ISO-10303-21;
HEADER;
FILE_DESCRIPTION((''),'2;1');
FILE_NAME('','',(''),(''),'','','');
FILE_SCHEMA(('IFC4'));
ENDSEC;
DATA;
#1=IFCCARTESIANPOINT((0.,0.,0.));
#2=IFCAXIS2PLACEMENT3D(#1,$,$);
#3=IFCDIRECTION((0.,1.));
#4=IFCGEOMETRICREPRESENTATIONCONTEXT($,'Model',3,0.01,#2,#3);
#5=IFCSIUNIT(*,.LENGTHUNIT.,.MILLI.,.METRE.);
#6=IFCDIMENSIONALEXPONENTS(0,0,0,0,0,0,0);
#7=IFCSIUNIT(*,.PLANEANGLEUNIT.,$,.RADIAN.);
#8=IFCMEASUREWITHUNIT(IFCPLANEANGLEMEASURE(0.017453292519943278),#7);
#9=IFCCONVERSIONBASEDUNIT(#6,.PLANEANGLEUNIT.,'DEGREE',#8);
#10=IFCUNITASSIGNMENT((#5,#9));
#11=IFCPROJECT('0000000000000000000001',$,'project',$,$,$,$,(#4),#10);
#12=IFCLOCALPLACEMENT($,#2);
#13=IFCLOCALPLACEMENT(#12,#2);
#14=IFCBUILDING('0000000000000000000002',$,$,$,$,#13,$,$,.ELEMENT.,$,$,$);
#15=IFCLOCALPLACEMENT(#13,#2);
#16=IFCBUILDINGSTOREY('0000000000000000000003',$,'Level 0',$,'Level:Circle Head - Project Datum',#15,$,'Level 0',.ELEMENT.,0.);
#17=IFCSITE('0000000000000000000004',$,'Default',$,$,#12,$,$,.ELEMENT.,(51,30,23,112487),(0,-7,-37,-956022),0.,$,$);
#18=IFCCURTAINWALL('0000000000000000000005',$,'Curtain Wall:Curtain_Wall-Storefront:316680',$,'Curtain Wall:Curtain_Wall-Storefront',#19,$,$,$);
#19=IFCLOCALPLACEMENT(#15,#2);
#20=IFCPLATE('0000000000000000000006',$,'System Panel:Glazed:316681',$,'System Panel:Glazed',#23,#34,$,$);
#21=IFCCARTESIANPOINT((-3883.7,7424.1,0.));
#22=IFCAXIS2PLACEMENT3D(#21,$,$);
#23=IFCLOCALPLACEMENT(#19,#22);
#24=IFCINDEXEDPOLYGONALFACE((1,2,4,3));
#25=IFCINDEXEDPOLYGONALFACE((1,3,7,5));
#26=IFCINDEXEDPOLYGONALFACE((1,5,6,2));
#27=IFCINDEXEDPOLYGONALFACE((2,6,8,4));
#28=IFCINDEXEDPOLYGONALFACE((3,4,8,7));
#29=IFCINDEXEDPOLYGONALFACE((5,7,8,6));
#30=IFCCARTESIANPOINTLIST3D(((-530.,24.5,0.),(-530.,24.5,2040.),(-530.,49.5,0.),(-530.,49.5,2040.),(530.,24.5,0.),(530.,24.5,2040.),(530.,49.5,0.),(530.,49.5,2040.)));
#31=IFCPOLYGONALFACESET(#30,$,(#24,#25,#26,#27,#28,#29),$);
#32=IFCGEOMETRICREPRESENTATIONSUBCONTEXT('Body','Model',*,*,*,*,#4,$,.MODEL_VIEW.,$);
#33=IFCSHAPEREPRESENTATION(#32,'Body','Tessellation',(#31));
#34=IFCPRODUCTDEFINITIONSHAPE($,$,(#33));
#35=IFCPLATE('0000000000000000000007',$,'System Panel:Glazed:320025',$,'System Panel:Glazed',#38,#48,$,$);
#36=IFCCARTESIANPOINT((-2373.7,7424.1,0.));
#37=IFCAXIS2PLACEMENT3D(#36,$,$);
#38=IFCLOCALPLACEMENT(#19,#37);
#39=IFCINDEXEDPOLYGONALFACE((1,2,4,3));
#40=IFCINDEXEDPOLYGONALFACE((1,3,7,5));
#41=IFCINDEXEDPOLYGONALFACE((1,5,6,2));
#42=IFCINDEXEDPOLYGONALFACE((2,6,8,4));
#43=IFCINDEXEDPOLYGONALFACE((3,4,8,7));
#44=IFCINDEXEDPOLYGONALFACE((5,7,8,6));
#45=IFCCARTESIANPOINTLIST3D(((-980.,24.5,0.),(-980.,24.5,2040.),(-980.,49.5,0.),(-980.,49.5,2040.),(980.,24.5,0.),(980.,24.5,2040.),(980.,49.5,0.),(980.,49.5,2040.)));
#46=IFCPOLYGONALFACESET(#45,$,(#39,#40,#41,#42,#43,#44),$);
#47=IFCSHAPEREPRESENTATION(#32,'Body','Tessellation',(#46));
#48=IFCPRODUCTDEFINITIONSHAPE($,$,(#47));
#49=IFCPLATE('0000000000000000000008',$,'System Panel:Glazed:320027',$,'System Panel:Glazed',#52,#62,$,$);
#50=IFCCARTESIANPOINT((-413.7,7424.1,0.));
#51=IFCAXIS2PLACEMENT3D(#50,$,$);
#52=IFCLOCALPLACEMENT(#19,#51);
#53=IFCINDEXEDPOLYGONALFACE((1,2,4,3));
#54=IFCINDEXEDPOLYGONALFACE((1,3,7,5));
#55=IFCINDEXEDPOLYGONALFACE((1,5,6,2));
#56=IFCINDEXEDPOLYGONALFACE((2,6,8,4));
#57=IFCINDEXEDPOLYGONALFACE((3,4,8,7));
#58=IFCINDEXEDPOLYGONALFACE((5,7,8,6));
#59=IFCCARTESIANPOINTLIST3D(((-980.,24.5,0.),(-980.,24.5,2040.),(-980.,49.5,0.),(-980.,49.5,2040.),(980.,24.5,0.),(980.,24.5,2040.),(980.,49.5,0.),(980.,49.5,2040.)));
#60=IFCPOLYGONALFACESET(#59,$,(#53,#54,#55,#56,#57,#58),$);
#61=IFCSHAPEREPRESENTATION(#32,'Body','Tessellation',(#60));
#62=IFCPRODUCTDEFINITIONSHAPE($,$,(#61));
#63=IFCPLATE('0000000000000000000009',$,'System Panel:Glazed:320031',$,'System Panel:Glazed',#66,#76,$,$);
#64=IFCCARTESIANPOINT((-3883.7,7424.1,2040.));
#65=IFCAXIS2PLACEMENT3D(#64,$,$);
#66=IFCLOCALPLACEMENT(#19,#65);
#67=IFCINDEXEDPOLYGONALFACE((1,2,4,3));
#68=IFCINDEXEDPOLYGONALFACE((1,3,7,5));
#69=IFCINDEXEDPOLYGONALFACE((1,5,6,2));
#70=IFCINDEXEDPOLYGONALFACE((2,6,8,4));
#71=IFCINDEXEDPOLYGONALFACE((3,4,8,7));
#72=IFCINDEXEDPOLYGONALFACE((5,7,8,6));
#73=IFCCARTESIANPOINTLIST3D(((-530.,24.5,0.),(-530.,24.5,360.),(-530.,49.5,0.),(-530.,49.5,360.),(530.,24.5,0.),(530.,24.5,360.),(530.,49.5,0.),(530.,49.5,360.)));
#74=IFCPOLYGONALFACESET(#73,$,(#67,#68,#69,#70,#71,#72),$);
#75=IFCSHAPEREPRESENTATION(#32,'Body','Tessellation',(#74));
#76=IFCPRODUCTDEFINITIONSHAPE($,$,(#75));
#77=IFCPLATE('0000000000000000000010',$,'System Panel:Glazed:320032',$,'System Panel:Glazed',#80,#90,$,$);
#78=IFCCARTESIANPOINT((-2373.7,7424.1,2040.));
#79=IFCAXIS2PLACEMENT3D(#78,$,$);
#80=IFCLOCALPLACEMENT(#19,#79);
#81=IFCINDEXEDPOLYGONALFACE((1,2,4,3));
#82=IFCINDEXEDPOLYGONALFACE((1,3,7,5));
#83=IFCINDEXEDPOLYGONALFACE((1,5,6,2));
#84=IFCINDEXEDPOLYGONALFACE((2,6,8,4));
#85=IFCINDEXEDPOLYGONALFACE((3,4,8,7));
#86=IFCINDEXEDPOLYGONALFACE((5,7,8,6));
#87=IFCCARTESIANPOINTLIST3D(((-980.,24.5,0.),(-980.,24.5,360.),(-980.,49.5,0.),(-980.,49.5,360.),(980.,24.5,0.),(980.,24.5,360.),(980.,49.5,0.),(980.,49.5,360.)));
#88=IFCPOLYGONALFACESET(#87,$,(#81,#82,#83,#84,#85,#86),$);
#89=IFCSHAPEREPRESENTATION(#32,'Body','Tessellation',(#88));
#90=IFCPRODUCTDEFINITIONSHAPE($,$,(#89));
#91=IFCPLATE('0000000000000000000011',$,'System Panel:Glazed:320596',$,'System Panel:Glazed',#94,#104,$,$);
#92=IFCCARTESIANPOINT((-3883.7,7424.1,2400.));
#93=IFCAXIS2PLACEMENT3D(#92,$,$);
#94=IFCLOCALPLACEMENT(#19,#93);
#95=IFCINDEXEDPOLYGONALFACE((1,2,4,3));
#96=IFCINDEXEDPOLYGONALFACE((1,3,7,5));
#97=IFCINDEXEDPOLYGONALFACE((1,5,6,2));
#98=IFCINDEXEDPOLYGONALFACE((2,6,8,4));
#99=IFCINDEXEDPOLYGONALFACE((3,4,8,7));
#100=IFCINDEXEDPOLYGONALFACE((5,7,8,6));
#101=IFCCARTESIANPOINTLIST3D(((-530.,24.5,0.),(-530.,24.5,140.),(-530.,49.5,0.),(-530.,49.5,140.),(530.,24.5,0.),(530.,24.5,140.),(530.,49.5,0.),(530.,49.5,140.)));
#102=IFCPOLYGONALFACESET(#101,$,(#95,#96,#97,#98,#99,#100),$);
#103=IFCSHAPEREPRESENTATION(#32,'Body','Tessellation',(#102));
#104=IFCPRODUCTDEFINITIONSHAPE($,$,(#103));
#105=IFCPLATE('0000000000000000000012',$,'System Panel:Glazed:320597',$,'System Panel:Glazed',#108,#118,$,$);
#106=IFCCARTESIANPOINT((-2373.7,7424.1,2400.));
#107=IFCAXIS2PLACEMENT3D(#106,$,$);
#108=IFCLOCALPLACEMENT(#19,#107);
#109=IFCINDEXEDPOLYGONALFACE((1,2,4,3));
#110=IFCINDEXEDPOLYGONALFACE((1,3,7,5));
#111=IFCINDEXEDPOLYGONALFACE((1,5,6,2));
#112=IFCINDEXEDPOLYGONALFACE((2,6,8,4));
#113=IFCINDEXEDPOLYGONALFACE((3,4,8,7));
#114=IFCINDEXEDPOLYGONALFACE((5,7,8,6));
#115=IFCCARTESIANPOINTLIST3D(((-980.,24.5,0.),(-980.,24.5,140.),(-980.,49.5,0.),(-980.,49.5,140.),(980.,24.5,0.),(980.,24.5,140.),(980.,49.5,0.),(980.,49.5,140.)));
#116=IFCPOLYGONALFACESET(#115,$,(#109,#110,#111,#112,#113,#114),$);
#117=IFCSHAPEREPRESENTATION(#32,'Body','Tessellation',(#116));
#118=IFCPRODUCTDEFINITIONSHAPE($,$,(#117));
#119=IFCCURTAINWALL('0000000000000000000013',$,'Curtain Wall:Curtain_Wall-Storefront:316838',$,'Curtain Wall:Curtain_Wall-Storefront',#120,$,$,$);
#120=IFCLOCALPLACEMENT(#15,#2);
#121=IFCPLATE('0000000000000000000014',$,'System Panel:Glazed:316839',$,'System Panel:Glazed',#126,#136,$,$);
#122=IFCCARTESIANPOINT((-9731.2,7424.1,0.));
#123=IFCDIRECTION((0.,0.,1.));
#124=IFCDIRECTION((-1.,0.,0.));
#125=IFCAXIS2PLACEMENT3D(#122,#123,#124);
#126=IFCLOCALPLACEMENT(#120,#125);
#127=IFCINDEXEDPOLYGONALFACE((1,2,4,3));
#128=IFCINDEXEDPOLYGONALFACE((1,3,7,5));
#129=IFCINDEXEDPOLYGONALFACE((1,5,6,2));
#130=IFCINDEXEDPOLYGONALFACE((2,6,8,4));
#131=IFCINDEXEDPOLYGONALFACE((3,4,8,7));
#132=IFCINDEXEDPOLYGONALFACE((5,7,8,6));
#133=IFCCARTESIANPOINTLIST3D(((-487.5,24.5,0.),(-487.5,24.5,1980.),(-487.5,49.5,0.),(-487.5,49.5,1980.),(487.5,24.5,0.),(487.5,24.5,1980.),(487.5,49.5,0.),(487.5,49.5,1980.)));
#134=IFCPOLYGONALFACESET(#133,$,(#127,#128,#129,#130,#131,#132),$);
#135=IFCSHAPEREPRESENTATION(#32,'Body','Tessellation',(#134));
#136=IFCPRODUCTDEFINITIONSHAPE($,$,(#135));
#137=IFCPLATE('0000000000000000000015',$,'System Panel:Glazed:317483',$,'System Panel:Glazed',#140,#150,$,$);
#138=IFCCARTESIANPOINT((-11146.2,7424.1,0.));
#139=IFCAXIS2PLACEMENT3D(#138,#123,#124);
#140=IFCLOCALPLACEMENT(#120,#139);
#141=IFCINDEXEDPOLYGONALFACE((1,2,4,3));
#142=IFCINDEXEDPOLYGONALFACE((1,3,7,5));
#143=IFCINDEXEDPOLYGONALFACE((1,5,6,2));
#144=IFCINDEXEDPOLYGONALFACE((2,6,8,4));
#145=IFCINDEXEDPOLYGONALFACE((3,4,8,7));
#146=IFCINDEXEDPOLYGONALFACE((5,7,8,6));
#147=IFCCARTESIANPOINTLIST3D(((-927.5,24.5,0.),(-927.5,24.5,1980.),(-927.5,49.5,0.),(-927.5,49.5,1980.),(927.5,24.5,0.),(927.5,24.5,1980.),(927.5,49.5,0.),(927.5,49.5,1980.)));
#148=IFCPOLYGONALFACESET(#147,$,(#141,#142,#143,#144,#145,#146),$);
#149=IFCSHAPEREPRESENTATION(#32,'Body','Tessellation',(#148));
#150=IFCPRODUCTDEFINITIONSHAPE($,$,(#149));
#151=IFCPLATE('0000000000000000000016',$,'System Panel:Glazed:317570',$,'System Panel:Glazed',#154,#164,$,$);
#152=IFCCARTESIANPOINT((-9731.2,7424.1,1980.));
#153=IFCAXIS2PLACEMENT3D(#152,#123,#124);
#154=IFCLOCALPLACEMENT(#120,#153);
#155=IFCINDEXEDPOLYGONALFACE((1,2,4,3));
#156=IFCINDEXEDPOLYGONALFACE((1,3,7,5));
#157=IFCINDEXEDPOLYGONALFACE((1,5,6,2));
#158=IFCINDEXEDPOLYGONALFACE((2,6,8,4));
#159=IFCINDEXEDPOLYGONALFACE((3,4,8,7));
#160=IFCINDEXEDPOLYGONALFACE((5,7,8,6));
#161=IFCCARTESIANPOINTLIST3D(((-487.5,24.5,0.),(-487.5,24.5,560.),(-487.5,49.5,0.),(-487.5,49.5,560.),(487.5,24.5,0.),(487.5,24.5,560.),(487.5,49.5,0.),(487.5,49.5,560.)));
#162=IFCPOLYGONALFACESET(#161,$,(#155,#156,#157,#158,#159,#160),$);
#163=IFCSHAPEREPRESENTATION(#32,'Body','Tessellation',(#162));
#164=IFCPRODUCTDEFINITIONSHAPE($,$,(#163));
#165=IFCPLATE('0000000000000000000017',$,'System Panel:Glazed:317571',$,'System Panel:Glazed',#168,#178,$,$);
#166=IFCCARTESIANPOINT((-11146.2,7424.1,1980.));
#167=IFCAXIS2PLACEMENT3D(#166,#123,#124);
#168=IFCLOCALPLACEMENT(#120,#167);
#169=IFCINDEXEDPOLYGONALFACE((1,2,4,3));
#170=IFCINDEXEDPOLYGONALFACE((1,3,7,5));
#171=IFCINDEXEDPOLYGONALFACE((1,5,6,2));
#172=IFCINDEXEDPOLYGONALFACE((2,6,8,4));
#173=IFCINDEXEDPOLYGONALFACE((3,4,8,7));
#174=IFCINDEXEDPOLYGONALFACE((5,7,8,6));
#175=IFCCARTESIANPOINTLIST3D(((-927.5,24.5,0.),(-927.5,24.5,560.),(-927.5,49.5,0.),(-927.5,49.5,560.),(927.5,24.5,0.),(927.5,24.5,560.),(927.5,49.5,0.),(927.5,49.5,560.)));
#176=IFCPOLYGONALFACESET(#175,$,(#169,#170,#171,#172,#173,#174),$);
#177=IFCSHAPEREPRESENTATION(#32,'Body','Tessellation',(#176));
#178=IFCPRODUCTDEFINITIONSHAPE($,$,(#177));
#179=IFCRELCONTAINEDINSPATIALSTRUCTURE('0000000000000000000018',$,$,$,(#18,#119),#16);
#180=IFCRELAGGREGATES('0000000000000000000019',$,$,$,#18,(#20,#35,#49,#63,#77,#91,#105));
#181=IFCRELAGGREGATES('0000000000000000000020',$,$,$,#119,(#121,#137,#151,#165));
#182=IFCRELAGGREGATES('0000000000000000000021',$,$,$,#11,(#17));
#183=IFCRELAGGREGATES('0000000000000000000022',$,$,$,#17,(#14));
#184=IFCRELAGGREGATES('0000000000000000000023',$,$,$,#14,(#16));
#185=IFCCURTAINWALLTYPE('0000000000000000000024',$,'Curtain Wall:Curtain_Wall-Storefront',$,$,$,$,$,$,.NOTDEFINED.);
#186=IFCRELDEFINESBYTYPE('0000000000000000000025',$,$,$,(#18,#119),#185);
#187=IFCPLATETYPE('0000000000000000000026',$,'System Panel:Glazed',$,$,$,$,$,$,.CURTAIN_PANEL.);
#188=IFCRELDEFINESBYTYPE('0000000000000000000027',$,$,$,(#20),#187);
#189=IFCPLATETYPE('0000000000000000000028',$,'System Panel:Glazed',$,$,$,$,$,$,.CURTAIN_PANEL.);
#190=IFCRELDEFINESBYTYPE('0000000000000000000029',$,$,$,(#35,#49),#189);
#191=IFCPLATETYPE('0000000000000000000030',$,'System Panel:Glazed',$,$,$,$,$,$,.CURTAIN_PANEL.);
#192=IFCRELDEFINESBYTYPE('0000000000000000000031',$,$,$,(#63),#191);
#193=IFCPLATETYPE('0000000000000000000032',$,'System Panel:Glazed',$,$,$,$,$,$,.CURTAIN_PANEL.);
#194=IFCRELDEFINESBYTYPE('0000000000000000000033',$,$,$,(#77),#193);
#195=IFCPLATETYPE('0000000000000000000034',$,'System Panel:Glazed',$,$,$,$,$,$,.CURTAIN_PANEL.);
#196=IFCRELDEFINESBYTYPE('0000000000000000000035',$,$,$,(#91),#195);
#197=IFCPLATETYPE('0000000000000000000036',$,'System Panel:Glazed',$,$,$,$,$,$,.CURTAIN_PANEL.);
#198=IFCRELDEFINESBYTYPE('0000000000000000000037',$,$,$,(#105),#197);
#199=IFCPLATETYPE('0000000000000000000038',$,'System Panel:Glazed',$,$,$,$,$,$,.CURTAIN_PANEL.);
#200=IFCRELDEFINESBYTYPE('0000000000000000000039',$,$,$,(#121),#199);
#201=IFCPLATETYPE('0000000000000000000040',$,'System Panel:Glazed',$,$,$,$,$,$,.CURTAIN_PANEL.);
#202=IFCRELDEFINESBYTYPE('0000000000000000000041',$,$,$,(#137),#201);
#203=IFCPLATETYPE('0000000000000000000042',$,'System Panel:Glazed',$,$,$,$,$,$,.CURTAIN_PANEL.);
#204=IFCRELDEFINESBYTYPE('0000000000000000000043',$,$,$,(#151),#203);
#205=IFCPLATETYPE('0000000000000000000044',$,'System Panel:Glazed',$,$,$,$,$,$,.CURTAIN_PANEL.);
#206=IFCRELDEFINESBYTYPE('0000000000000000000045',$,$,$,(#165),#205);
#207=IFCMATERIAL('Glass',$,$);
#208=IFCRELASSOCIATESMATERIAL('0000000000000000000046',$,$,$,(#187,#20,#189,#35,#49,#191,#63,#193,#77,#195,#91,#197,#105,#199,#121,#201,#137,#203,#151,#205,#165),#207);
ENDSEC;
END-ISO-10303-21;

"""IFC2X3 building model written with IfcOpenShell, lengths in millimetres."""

from ifc_helpers import new_model, entity, si_unit, converted_unit, direction, frame, origin, origin_2d_with_axis, place, context, subcontext, project, spatial, rectangle, extrude, source, transform, mapped, material, type_object, type_shapes, element, aggregate, save


model = new_model("IFC2X3")

# Units and contexts
model_context = context("Model", 3, precision=0.01, world=origin(), true_north=direction((0.0, 1.0)))
body_context = subcontext(model_context, "Body", "Model", "MODEL_VIEW")
ifc_project = project(units=[si_unit("LENGTHUNIT", "METRE", prefix="MILLI"), converted_unit("PLANEANGLEUNIT", "DEGREE", entity("IfcPlaneAngleMeasure", 0.017453292519943278), si_unit("PLANEANGLEUNIT", "RADIAN"), dimensions=[0, 0, 0, 0, 0, 0, 0])], contexts=[model_context])

# Site, building, storey
site_placement = place(None, origin())
site = spatial("IfcSite", under=ifc_project, at=site_placement, Name="Default", CompositionType="ELEMENT", RefLatitude=(51, 30, 23, 112487), RefLongitude=(0, -7, -37, -956022), RefElevation=0.0)
building_placement = place(site_placement, origin())
building = spatial("IfcBuilding", under=site, at=building_placement, CompositionType="ELEMENT")
storey_placement = place(building_placement, origin())
storey = spatial("IfcBuildingStorey", under=building, at=storey_placement, Name="Level 0", ObjectType="Level:Circle Head - Project Datum", LongName="Level 0", CompositionType="ELEMENT", Elevation=0.0)

# Curtain walls, plates
curtain_wall_type = type_object("IfcCurtainWallType", Name="Curtain Wall:Curtain_Wall-Storefront", PredefinedType="NOTDEFINED")
curtain_wall_1_placement = place(storey_placement, origin())
curtain_wall_1 = element("IfcCurtainWall", 1, at=curtain_wall_1_placement, inside=storey, type_object=curtain_wall_type, Name="Curtain Wall:Curtain_Wall-Storefront:316680", ObjectType="Curtain Wall:Curtain_Wall-Storefront")
ifc_material_1 = material(Name="Glass")
plate_type_1 = type_object("IfcPlateType", Name="System Panel:Glazed", PredefinedType="CURTAIN_PANEL", material=ifc_material_1)
shared_shape_1 = source(origin(), body_context, "Body", "SweptSolid", [
    extrude(rectangle(XDim=25.0, YDim=1060.0, at=origin_2d_with_axis()), frame((0.0, 37.0, 0.0), z_axis=(0.0, 0.0, 1.0), x_axis=(0.0, 1.0, 0.0)), (0.0, 0.0, 1.0), 2040.0),
])
type_shapes(plate_type_1, [shared_shape_1])
plate_1_placement = place(curtain_wall_1_placement, frame((-3883.7, 7424.1, 0.0)))
plate_1 = element("IfcPlate", 2, at=plate_1_placement, type_object=plate_type_1, material=ifc_material_1, Name="System Panel:Glazed:316681", ObjectType="System Panel:Glazed", context=body_context, shape_type="MappedRepresentation", body=[
    mapped(shared_shape_1, transform((0.0, 0.0, 0.0), scale=1.0)),
])
plate_type_2 = type_object("IfcPlateType", Name="System Panel:Glazed", PredefinedType="CURTAIN_PANEL", material=ifc_material_1)
shared_shape_2 = source(origin(), body_context, "Body", "SweptSolid", [
    extrude(rectangle(XDim=25.0, YDim=1960.0, at=origin_2d_with_axis()), frame((0.0, 37.0, 0.0), z_axis=(0.0, 0.0, 1.0), x_axis=(0.0, 1.0, 0.0)), (0.0, 0.0, 1.0), 2040.0),
])
type_shapes(plate_type_2, [shared_shape_2])
plate_2_placement = place(curtain_wall_1_placement, frame((-2373.7, 7424.1, 0.0)))
plate_2 = element("IfcPlate", 3, at=plate_2_placement, type_object=plate_type_2, material=ifc_material_1, Name="System Panel:Glazed:320025", ObjectType="System Panel:Glazed", context=body_context, shape_type="MappedRepresentation", body=[
    mapped(shared_shape_2, transform((0.0, 0.0, 0.0), scale=1.0)),
])
plate_3_placement = place(curtain_wall_1_placement, frame((-413.7, 7424.1, 0.0)))
plate_3 = element("IfcPlate", 4, at=plate_3_placement, type_object=plate_type_2, material=ifc_material_1, Name="System Panel:Glazed:320027", ObjectType="System Panel:Glazed", context=body_context, shape_type="MappedRepresentation", body=[
    mapped(shared_shape_2, transform((0.0, 0.0, 0.0), scale=1.0)),
])
plate_type_3 = type_object("IfcPlateType", Name="System Panel:Glazed", PredefinedType="CURTAIN_PANEL", material=ifc_material_1)
shared_shape_3 = source(origin(), body_context, "Body", "SweptSolid", [
    extrude(rectangle(XDim=25.0, YDim=1060.0, at=origin_2d_with_axis()), frame((0.0, 37.0, 0.0), z_axis=(0.0, 0.0, 1.0), x_axis=(0.0, 1.0, 0.0)), (0.0, 0.0, 1.0), 360.0),
])
type_shapes(plate_type_3, [shared_shape_3])
plate_4_placement = place(curtain_wall_1_placement, frame((-3883.7, 7424.1, 2040.0)))
plate_4 = element("IfcPlate", 5, at=plate_4_placement, type_object=plate_type_3, material=ifc_material_1, Name="System Panel:Glazed:320031", ObjectType="System Panel:Glazed", context=body_context, shape_type="MappedRepresentation", body=[
    mapped(shared_shape_3, transform((0.0, 0.0, 0.0), scale=1.0)),
])
plate_type_4 = type_object("IfcPlateType", Name="System Panel:Glazed", PredefinedType="CURTAIN_PANEL", material=ifc_material_1)
shared_shape_4 = source(origin(), body_context, "Body", "SweptSolid", [
    extrude(rectangle(XDim=25.0, YDim=1960.0, at=origin_2d_with_axis()), frame((0.0, 37.0, 0.0), z_axis=(0.0, 0.0, 1.0), x_axis=(0.0, 1.0, 0.0)), (0.0, 0.0, 1.0), 360.0),
])
type_shapes(plate_type_4, [shared_shape_4])
plate_5_placement = place(curtain_wall_1_placement, frame((-2373.7, 7424.1, 2040.0)))
plate_5 = element("IfcPlate", 6, at=plate_5_placement, type_object=plate_type_4, material=ifc_material_1, Name="System Panel:Glazed:320032", ObjectType="System Panel:Glazed", context=body_context, shape_type="MappedRepresentation", body=[
    mapped(shared_shape_4, transform((0.0, 0.0, 0.0), scale=1.0)),
])
plate_type_5 = type_object("IfcPlateType", Name="System Panel:Glazed", PredefinedType="CURTAIN_PANEL", material=ifc_material_1)
shared_shape_5 = source(origin(), body_context, "Body", "SweptSolid", [
    extrude(rectangle(XDim=25.0, YDim=1060.0, at=origin_2d_with_axis()), frame((0.0, 37.0, 0.0), z_axis=(0.0, 0.0, 1.0), x_axis=(0.0, 1.0, 0.0)), (0.0, 0.0, 1.0), 140.0),
])
type_shapes(plate_type_5, [shared_shape_5])
plate_6_placement = place(curtain_wall_1_placement, frame((-3883.7, 7424.1, 2400.0)))
plate_6 = element("IfcPlate", 7, at=plate_6_placement, type_object=plate_type_5, material=ifc_material_1, Name="System Panel:Glazed:320596", ObjectType="System Panel:Glazed", context=body_context, shape_type="MappedRepresentation", body=[
    mapped(shared_shape_5, transform((0.0, 0.0, 0.0), scale=1.0)),
])
plate_type_6 = type_object("IfcPlateType", Name="System Panel:Glazed", PredefinedType="CURTAIN_PANEL", material=ifc_material_1)
shared_shape_6 = source(origin(), body_context, "Body", "SweptSolid", [
    extrude(rectangle(XDim=25.0, YDim=1960.0, at=origin_2d_with_axis()), frame((0.0, 37.0, 0.0), z_axis=(0.0, 0.0, 1.0), x_axis=(0.0, 1.0, 0.0)), (0.0, 0.0, 1.0), 140.0),
])
type_shapes(plate_type_6, [shared_shape_6])
plate_7_placement = place(curtain_wall_1_placement, frame((-2373.7, 7424.1, 2400.0)))
plate_7 = element("IfcPlate", 8, at=plate_7_placement, type_object=plate_type_6, material=ifc_material_1, Name="System Panel:Glazed:320597", ObjectType="System Panel:Glazed", context=body_context, shape_type="MappedRepresentation", body=[
    mapped(shared_shape_6, transform((0.0, 0.0, 0.0), scale=1.0)),
])
aggregate(curtain_wall_1, [plate_1, plate_2, plate_3, plate_4, plate_5, plate_6, plate_7])
curtain_wall_2_placement = place(storey_placement, origin())
curtain_wall_2 = element("IfcCurtainWall", 9, at=curtain_wall_2_placement, inside=storey, type_object=curtain_wall_type, Name="Curtain Wall:Curtain_Wall-Storefront:316838", ObjectType="Curtain Wall:Curtain_Wall-Storefront")
plate_type_7 = type_object("IfcPlateType", Name="System Panel:Glazed", PredefinedType="CURTAIN_PANEL", material=ifc_material_1)
shared_shape_7 = source(origin(), body_context, "Body", "SweptSolid", [
    extrude(rectangle(XDim=25.0, YDim=975.0, at=origin_2d_with_axis()), frame((0.0, 37.0, 0.0), z_axis=(0.0, 0.0, 1.0), x_axis=(0.0, 1.0, 0.0)), (0.0, 0.0, 1.0), 1980.0),
])
type_shapes(plate_type_7, [shared_shape_7])
plate_8_placement = place(curtain_wall_2_placement, frame((-9731.2, 7424.1, 0.0), z_axis=(0.0, 0.0, 1.0), x_axis=(-1.0, 0.0, 0.0)))
plate_8 = element("IfcPlate", 10, at=plate_8_placement, type_object=plate_type_7, material=ifc_material_1, Name="System Panel:Glazed:316839", ObjectType="System Panel:Glazed", context=body_context, shape_type="MappedRepresentation", body=[
    mapped(shared_shape_7, transform((0.0, 0.0, 0.0), scale=1.0)),
])
plate_type_8 = type_object("IfcPlateType", Name="System Panel:Glazed", PredefinedType="CURTAIN_PANEL", material=ifc_material_1)
shared_shape_8 = source(origin(), body_context, "Body", "SweptSolid", [
    extrude(rectangle(XDim=25.0, YDim=1855.0, at=origin_2d_with_axis()), frame((0.0, 37.0, 0.0), z_axis=(0.0, 0.0, 1.0), x_axis=(0.0, 1.0, 0.0)), (0.0, 0.0, 1.0), 1980.0),
])
type_shapes(plate_type_8, [shared_shape_8])
plate_9_placement = place(curtain_wall_2_placement, frame((-11146.2, 7424.1, 0.0), z_axis=(0.0, 0.0, 1.0), x_axis=(-1.0, 0.0, 0.0)))
plate_9 = element("IfcPlate", 11, at=plate_9_placement, type_object=plate_type_8, material=ifc_material_1, Name="System Panel:Glazed:317483", ObjectType="System Panel:Glazed", context=body_context, shape_type="MappedRepresentation", body=[
    mapped(shared_shape_8, transform((0.0, 0.0, 0.0), scale=1.0)),
])
plate_type_9 = type_object("IfcPlateType", Name="System Panel:Glazed", PredefinedType="CURTAIN_PANEL", material=ifc_material_1)
shared_shape_9 = source(origin(), body_context, "Body", "SweptSolid", [
    extrude(rectangle(XDim=25.0, YDim=975.0, at=origin_2d_with_axis()), frame((0.0, 37.0, 0.0), z_axis=(0.0, 0.0, 1.0), x_axis=(0.0, 1.0, 0.0)), (0.0, 0.0, 1.0), 560.0),
])
type_shapes(plate_type_9, [shared_shape_9])
plate_10_placement = place(curtain_wall_2_placement, frame((-9731.2, 7424.1, 1980.0), z_axis=(0.0, 0.0, 1.0), x_axis=(-1.0, 0.0, 0.0)))
plate_10 = element("IfcPlate", 12, at=plate_10_placement, type_object=plate_type_9, material=ifc_material_1, Name="System Panel:Glazed:317570", ObjectType="System Panel:Glazed", context=body_context, shape_type="MappedRepresentation", body=[
    mapped(shared_shape_9, transform((0.0, 0.0, 0.0), scale=1.0)),
])
plate_type_10 = type_object("IfcPlateType", Name="System Panel:Glazed", PredefinedType="CURTAIN_PANEL", material=ifc_material_1)
shared_shape_10 = source(origin(), body_context, "Body", "SweptSolid", [
    extrude(rectangle(XDim=25.0, YDim=1855.0, at=origin_2d_with_axis()), frame((0.0, 37.0, 0.0), z_axis=(0.0, 0.0, 1.0), x_axis=(0.0, 1.0, 0.0)), (0.0, 0.0, 1.0), 560.0),
])
type_shapes(plate_type_10, [shared_shape_10])
plate_11_placement = place(curtain_wall_2_placement, frame((-11146.2, 7424.1, 1980.0), z_axis=(0.0, 0.0, 1.0), x_axis=(-1.0, 0.0, 0.0)))
plate_11 = element("IfcPlate", 13, at=plate_11_placement, type_object=plate_type_10, material=ifc_material_1, Name="System Panel:Glazed:317571", ObjectType="System Panel:Glazed", context=body_context, shape_type="MappedRepresentation", body=[
    mapped(shared_shape_10, transform((0.0, 0.0, 0.0), scale=1.0)),
])
aggregate(curtain_wall_2, [plate_8, plate_9, plate_10, plate_11])

save(model, "model.ifc")
